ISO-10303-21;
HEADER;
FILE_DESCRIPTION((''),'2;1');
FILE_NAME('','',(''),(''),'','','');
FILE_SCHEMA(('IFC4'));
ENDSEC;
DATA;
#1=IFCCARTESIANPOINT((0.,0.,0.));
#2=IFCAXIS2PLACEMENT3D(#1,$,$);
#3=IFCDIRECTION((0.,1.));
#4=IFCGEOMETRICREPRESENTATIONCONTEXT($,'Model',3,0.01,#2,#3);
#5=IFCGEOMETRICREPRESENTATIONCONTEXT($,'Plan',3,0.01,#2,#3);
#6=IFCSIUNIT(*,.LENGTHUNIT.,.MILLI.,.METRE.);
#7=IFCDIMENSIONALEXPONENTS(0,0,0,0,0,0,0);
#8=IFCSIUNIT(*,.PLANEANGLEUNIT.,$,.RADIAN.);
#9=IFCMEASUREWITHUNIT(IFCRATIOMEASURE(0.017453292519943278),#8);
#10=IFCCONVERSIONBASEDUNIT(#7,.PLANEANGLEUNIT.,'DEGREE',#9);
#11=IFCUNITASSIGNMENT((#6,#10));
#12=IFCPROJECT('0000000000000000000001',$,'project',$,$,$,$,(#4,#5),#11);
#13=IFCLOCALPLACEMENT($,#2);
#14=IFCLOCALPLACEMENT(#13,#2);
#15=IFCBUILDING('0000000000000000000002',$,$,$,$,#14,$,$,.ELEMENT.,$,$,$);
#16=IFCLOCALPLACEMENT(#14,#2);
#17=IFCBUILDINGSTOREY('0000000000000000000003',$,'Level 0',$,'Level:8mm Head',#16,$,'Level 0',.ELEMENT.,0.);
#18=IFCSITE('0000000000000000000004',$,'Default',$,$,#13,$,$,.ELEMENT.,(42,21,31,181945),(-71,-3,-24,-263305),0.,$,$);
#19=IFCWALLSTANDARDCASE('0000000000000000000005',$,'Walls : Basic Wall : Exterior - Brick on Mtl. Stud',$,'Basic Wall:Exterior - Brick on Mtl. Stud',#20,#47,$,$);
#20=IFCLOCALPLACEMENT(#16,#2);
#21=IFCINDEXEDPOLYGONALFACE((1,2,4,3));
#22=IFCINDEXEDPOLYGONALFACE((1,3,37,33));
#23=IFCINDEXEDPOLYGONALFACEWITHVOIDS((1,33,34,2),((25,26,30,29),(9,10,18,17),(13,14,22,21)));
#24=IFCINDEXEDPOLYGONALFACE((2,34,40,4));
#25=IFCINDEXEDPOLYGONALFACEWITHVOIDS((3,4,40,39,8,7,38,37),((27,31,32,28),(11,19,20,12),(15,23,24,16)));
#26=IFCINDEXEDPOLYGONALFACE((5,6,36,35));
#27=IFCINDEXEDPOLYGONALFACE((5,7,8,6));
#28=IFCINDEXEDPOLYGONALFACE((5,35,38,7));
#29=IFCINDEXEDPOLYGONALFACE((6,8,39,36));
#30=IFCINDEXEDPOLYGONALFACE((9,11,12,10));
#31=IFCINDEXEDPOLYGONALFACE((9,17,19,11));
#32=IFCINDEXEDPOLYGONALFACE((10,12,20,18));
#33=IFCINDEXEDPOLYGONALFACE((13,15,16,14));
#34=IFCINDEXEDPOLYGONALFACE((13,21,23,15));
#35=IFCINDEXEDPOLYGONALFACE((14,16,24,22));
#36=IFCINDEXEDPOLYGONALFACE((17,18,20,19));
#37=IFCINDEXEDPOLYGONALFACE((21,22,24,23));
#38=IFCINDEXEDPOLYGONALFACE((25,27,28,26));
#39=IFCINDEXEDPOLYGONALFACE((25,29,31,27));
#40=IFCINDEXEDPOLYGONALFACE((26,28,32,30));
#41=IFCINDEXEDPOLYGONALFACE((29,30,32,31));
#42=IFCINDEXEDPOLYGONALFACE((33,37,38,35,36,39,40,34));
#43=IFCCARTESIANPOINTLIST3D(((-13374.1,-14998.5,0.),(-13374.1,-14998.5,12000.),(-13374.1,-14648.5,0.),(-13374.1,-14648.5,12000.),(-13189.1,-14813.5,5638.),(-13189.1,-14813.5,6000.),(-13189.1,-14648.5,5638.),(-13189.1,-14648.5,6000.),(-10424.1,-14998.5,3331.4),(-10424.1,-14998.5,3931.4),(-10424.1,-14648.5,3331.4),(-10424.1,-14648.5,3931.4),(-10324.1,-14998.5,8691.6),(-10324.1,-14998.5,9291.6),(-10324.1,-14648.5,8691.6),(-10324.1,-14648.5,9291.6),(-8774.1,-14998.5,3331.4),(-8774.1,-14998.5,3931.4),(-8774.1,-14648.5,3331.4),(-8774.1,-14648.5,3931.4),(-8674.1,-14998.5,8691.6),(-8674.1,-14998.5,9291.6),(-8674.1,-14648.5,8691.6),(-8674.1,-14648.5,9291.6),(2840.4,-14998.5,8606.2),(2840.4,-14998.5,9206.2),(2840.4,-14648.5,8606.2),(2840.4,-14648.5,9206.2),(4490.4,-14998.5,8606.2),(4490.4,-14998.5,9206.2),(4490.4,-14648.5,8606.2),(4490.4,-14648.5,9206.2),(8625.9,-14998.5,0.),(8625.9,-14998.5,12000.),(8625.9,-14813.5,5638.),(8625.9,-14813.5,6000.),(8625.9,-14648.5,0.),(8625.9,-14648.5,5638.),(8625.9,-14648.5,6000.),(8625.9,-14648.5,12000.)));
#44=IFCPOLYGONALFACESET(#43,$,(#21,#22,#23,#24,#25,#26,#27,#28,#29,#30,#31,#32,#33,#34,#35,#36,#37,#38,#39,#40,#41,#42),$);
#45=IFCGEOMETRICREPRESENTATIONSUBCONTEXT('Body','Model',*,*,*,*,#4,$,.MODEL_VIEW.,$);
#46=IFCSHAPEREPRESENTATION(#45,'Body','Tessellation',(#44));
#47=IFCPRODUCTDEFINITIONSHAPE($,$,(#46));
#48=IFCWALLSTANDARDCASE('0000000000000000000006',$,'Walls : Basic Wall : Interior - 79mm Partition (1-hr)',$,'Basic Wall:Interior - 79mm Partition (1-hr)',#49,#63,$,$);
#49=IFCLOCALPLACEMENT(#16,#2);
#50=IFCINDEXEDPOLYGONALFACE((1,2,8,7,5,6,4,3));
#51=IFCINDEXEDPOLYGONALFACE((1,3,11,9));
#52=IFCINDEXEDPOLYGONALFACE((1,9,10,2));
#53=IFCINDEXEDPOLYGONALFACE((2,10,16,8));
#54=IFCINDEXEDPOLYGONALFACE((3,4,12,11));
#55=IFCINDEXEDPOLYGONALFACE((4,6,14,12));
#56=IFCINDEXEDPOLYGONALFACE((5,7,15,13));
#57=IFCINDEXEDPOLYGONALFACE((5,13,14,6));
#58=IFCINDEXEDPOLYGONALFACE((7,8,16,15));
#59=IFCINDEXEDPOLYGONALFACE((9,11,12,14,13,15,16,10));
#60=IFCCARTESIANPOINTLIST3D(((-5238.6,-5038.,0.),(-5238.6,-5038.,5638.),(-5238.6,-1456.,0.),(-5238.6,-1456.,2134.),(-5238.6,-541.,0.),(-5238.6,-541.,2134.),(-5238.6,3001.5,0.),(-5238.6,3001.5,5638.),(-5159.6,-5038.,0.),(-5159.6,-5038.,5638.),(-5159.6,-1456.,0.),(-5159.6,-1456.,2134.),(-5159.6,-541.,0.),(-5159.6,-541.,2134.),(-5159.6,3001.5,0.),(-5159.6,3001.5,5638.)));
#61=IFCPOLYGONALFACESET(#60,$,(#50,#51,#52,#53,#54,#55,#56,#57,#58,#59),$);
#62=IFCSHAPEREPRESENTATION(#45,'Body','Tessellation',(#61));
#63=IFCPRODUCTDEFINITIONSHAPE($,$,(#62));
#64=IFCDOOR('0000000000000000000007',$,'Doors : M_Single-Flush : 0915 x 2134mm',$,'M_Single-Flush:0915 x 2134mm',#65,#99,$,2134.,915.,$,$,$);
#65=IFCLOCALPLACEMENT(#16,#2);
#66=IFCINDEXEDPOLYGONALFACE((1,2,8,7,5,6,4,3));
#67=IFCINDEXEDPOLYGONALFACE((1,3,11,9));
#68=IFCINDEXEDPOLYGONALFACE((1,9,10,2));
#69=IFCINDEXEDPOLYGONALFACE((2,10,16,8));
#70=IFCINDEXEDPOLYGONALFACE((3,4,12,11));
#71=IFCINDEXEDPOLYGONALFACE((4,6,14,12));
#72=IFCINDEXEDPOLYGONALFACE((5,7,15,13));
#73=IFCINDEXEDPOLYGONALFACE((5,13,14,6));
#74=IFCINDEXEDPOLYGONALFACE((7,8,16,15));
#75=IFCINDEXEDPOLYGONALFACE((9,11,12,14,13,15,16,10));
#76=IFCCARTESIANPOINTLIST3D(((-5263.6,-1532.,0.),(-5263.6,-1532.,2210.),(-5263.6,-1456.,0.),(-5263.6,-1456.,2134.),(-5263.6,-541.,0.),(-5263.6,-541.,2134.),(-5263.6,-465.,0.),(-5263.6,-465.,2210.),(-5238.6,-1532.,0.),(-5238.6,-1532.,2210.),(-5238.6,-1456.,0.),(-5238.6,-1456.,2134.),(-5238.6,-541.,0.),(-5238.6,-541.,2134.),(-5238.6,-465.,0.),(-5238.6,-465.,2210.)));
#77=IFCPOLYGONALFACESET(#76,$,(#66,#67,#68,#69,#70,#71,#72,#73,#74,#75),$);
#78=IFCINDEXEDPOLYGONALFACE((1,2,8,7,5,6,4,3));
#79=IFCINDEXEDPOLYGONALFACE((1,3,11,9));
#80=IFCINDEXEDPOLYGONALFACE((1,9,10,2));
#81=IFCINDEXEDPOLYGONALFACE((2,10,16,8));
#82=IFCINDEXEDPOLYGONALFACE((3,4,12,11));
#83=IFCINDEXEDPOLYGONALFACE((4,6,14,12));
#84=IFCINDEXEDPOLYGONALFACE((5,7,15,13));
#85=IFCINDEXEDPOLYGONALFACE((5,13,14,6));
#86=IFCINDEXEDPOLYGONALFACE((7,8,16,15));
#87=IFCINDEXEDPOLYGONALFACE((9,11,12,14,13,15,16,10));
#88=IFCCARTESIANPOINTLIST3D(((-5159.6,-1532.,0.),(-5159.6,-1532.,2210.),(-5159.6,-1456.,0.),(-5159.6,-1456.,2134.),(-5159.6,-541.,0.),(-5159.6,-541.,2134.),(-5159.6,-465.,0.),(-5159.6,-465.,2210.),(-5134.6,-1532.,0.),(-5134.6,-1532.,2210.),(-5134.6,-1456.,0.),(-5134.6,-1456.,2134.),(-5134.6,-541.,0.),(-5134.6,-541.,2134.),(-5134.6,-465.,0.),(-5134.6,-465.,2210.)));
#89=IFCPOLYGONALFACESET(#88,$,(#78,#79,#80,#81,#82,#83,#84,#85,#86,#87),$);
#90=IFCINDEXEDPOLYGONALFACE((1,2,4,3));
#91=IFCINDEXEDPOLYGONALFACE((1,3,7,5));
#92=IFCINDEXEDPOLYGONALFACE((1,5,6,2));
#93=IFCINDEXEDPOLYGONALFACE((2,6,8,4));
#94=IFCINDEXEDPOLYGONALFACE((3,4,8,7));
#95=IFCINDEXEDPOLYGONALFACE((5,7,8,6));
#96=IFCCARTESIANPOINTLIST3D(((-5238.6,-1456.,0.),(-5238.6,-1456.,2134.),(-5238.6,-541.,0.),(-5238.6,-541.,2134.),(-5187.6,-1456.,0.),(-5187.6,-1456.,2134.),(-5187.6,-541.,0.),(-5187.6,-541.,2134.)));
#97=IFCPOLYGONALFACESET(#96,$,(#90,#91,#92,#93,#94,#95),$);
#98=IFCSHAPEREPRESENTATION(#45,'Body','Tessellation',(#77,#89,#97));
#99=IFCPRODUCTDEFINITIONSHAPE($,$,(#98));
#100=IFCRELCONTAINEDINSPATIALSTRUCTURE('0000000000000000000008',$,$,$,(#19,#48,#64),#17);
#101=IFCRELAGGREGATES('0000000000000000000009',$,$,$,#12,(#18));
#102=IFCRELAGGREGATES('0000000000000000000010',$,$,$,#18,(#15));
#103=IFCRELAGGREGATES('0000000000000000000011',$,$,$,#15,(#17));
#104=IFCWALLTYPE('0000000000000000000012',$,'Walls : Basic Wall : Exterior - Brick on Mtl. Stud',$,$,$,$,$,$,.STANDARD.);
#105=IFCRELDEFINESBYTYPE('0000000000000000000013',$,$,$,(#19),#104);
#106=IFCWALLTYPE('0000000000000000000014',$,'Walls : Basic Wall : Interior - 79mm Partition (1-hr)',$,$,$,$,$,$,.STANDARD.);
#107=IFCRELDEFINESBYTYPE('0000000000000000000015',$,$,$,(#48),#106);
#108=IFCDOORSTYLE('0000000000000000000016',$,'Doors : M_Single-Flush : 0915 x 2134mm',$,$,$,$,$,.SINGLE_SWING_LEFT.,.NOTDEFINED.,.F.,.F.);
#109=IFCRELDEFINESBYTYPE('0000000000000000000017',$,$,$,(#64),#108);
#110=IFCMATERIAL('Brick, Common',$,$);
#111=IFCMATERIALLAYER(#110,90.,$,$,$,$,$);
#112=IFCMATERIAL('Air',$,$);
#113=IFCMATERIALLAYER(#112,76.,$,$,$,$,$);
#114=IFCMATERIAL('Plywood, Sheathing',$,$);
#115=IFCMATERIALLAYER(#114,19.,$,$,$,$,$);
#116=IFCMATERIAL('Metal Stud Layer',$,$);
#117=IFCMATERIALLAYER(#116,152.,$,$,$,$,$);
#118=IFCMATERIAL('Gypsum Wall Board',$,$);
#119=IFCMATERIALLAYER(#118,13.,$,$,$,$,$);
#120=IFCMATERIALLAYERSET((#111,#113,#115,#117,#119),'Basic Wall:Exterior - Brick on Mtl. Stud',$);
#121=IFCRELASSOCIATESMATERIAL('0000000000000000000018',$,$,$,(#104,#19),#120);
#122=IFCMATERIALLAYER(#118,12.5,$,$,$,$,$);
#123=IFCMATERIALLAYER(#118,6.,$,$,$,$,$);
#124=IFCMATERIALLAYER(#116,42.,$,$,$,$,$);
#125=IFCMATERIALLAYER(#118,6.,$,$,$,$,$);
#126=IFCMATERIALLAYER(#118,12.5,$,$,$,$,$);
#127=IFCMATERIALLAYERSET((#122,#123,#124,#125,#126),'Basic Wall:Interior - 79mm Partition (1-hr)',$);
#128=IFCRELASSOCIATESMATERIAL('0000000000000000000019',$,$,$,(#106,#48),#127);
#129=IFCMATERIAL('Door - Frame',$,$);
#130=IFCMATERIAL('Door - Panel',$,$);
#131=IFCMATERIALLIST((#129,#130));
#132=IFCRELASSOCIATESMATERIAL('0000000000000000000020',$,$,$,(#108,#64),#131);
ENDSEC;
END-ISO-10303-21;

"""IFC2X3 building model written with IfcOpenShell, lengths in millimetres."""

from ifc_helpers import new_model, entity, si_unit, converted_unit, direction, frame, frame_2d, origin, origin_2d_with_axis, place, context, subcontext, project, spatial, polyline, rectangle, outline, extrude, clip, bounded_halfspace, source, transform, mapped, material, material_list, layer, layer_set, layer_usage, type_object, type_shapes, element, fill, save


model = new_model("IFC2X3")

# Units and contexts
model_context = context("Model", 3, precision=0.01, world=origin(), true_north=direction((0.0, 1.0)))
plan_context = context("Plan", 3, precision=0.01, world=origin(), true_north=direction((0.0, 1.0)))
body_context = subcontext(model_context, "Body", "Model", "MODEL_VIEW")
ifc_project = project(units=[si_unit("LENGTHUNIT", "METRE", prefix="MILLI"), converted_unit("PLANEANGLEUNIT", "DEGREE", entity("IfcRatioMeasure", 0.017453292519943278), si_unit("PLANEANGLEUNIT", "RADIAN"), dimensions=[0, 0, 0, 0, 0, 0, 0])], contexts=[model_context, plan_context])

# Site, building, storey
site_placement = place(None, origin())
site = spatial("IfcSite", under=ifc_project, at=site_placement, Name="Default", CompositionType="ELEMENT", RefLatitude=(42, 21, 31, 181945), RefLongitude=(-71, -3, -24, -263305), RefElevation=0.0)
building_placement = place(site_placement, origin())
building = spatial("IfcBuilding", under=site, at=building_placement, CompositionType="ELEMENT")
storey_placement = place(building_placement, origin())
storey = spatial("IfcBuildingStorey", under=building, at=storey_placement, Name="Level 0", ObjectType="Level:8mm Head", LongName="Level 0", CompositionType="ELEMENT", Elevation=0.0)

# Shared definitions
ifc_material_1 = material(Name="Air")
ifc_material_2 = material(Name="Plywood, Sheathing")
ifc_material_3 = material(Name="Metal Stud Layer")
ifc_material_4 = material(Name="Gypsum Wall Board")

# Shared definitions
ifc_material_5 = material(Name="Brick, Common")
ifc_layer_1 = layer(ifc_material_5, 90.0)
ifc_layer_2 = layer(ifc_material_1, 76.0)
ifc_layer_3 = layer(ifc_material_2, 19.0)
ifc_layer_4 = layer(ifc_material_3, 152.0)
ifc_layer_5 = layer(ifc_material_4, 13.0)
ifc_layer_set_1 = layer_set([ifc_layer_1, ifc_layer_2, ifc_layer_3, ifc_layer_4, ifc_layer_5], Name="Basic Wall:Exterior - Brick on Mtl. Stud")
ifc_layer_usage_1 = layer_usage(ifc_layer_set_1, "AXIS2", "NEGATIVE", 175.0)
wall_type_1 = type_object("IfcWallType", Name="Walls : Basic Wall : Exterior - Brick on Mtl. Stud", PredefinedType="STANDARD", material=ifc_layer_set_1)
ifc_material_6 = material(Name="Door - Frame")
ifc_material_7 = material(Name="Door - Panel")
ifc_material_list = material_list([ifc_material_6, ifc_material_7])

# Wall, openings
wall_1_placement = place(storey_placement, frame((8625.9, -14823.5, 0.0), z_axis=(0.0, 0.0, 1.0), x_axis=(-1.0, 0.0, 0.0)))
wall_1 = element("IfcWallStandardCase", 1, at=wall_1_placement, inside=storey, type_object=wall_type_1, material=ifc_layer_usage_1, Name="Walls : Basic Wall : Exterior - Brick on Mtl. Stud", ObjectType="Basic Wall:Exterior - Brick on Mtl. Stud", context=body_context, shape_type="SweptSolid", body=[
    extrude(rectangle(XDim=22000.0, YDim=350.0, at=frame_2d((11000.0, 0.0), x_axis=(-1.0, 0.0))), origin(), (0.0, 0.0, 1.0), 12000.0),
])
opening_1_placement = place(storey_placement, frame((8625.9, -14823.5, 0.0), z_axis=(0.0, 0.0, 1.0), x_axis=(-1.0, 0.0, 0.0)))
element("IfcOpeningElement", 2, at=opening_1_placement, cuts=wall_1, ObjectType="Opening", context=body_context, shape_type="SweptSolid", body=[
    extrude(rectangle(XDim=165.0, YDim=21815.0, at=frame_2d((35.4, 82.5), x_axis=(1.0, 0.0))), frame((10990.0, -127.9, 5638.0), z_axis=(0.0, 0.0, 1.0), x_axis=(0.0, 1.0, 0.0)), (0.0, 0.0, 1.0), 362.0),
])
opening_2_placement = place(wall_1_placement, frame((17300.0, -175.0, 8691.6)))
element("IfcOpeningElement", 3, at=opening_2_placement, cuts=wall_1, ObjectType="Opening", context=body_context, shape_type="SweptSolid", body=[
    extrude(rectangle(XDim=600.0, YDim=1650.0, at=frame_2d((300.0, 825.0), x_axis=(-1.0, 0.0))), frame((0.0, 0.0, 0.0), z_axis=(0.0, 1.0, 0.0), x_axis=(0.0, 0.0, 1.0)), (0.0, 0.0, 1.0), 350.0),
])
opening_3_placement = place(wall_1_placement, frame((4135.5, -175.0, 8606.2)))
element("IfcOpeningElement", 4, at=opening_3_placement, cuts=wall_1, ObjectType="Opening", context=body_context, shape_type="SweptSolid", body=[
    extrude(rectangle(XDim=600.0, YDim=1650.0, at=frame_2d((300.0, 825.0), x_axis=(-1.0, 0.0))), frame((0.0, 0.0, 0.0), z_axis=(0.0, 1.0, 0.0), x_axis=(0.0, 0.0, 1.0)), (0.0, 0.0, 1.0), 350.0),
])
opening_4_placement = place(wall_1_placement, frame((17400.0, -175.0, 3331.4)))
element("IfcOpeningElement", 5, at=opening_4_placement, cuts=wall_1, ObjectType="Opening", context=body_context, shape_type="SweptSolid", body=[
    extrude(rectangle(XDim=600.0, YDim=1650.0, at=frame_2d((300.0, 825.0), x_axis=(-1.0, 0.0))), frame((0.0, 0.0, 0.0), z_axis=(0.0, 1.0, 0.0), x_axis=(0.0, 0.0, 1.0)), (0.0, 0.0, 1.0), 350.0),
])

# Wall, opening, door
ifc_layer_6 = layer(ifc_material_4, 12.5)
ifc_layer_7 = layer(ifc_material_4, 6.0)
ifc_layer_8 = layer(ifc_material_3, 42.0)
ifc_layer_9 = layer(ifc_material_4, 6.0)
ifc_layer_10 = layer(ifc_material_4, 12.5)
ifc_layer_set_2 = layer_set([ifc_layer_6, ifc_layer_7, ifc_layer_8, ifc_layer_9, ifc_layer_10], Name="Basic Wall:Interior - 79mm Partition (1-hr)")
ifc_layer_usage_2 = layer_usage(ifc_layer_set_2, "AXIS2", "NEGATIVE", 39.5)
wall_type_2 = type_object("IfcWallType", Name="Walls : Basic Wall : Interior - 79mm Partition (1-hr)", PredefinedType="STANDARD", material=ifc_layer_set_2)
wall_2_placement = place(storey_placement, frame((-5199.1, 3001.5, 0.0), z_axis=(0.0, 0.0, 1.0), x_axis=(0.0, -1.0, 0.0)))
wall_2 = element("IfcWallStandardCase", 6, at=wall_2_placement, inside=storey, type_object=wall_type_2, material=ifc_layer_usage_2, Name="Walls : Basic Wall : Interior - 79mm Partition (1-hr)", ObjectType="Basic Wall:Interior - 79mm Partition (1-hr)", context=body_context, shape_type="Clipping", body=[
    clip(extrude(rectangle(XDim=8039.5, YDim=79.0, at=frame_2d((4019.8, 0.0), x_axis=(1.0, 0.0))), origin(), (0.0, 0.0, 1.0), 5638.0), bounded_halfspace(frame((0.0, -39.5, 5638.0), z_axis=(0.0, 0.0, -1.0), x_axis=(1.0, 0.0, 0.0)), True, frame((0.0, -39.5, 5638.0)), polyline([(0.0, 0.0), (2450439.6, 0.0), (2450439.6, 24079.2), (2426360.4, 24079.2), (0.0, 24079.2), (0.0, 0.0)]))),
])
opening_5_placement = place(wall_2_placement, frame((4457.5, 39.5, 0.0)))
opening_5 = element("IfcOpeningElement", 7, at=opening_5_placement, cuts=wall_2, ObjectType="Opening", context=body_context, shape_type="SweptSolid", body=[
    extrude(rectangle(XDim=915.0, YDim=2134.0, at=frame_2d((1067.0, 457.5), x_axis=(0.0, -1.0))), frame((0.0, 0.0, 0.0), z_axis=(0.0, -1.0, 0.0), x_axis=(0.0, 0.0, 1.0)), (0.0, 0.0, 1.0), 79.0),
])
door_style_1 = type_object("IfcDoorStyle", Name="Doors : M_Single-Flush : 0915 x 2134mm", ConstructionType="NOTDEFINED", OperationType="SINGLE_SWING_LEFT", ParameterTakesPrecedence=False, Sizeable=False, material=ifc_material_list)
shared_shape_1 = source(origin(), body_context, "Body", "SweptSolid", [
    extrude(outline(polyline([(-533.5, -1124.0), (533.5, -1124.0), (533.5, 1086.0), (457.5, 1086.0), (457.5, -1048.0), (-457.5, -1048.0), (-457.5, 1086.0), (-533.5, 1086.0), (-533.5, -1124.0)])), frame((457.5, 104.0, 1086.0), z_axis=(0.0, -1.0, 0.0), x_axis=(-1.0, 0.0, 0.0)), (0.0, 0.0, 1.0), 25.0),
    extrude(outline(polyline([(-1124.0, -533.5), (1086.0, -533.5), (1086.0, -457.5), (-1048.0, -457.5), (-1048.0, 457.5), (1086.0, 457.5), (1086.0, 533.5), (-1124.0, 533.5), (-1124.0, -533.5)])), frame((457.5, 0.0, 1086.0), z_axis=(0.0, -1.0, 0.0), x_axis=(0.0, 0.0, -1.0)), (0.0, 0.0, 1.0), 25.0),
    extrude(rectangle(XDim=915.0, YDim=51.0, at=origin_2d_with_axis()), frame((457.5, 53.5, 0.0)), (0.0, 0.0, 1.0), 2134.0),
])
type_shapes(door_style_1, [shared_shape_1])
door_1_placement = place(opening_5_placement, frame((0.0, 0.0, 0.0), z_axis=(0.0, 0.0, 1.0), x_axis=(-1.0, 0.0, 0.0)))
door_1 = element("IfcDoor", 8, at=door_1_placement, inside=storey, type_object=door_style_1, material=ifc_material_list, Name="Doors : M_Single-Flush : 0915 x 2134mm", ObjectType="M_Single-Flush:0915 x 2134mm", OverallHeight=2134.0, OverallWidth=915.0, context=body_context, shape_type="MappedRepresentation", body=[
    mapped(shared_shape_1, transform((0.0, 0.0, 0.0), scale=1.0)),
])
fill(opening_5, door_1)

save(model, "model.ifc")
